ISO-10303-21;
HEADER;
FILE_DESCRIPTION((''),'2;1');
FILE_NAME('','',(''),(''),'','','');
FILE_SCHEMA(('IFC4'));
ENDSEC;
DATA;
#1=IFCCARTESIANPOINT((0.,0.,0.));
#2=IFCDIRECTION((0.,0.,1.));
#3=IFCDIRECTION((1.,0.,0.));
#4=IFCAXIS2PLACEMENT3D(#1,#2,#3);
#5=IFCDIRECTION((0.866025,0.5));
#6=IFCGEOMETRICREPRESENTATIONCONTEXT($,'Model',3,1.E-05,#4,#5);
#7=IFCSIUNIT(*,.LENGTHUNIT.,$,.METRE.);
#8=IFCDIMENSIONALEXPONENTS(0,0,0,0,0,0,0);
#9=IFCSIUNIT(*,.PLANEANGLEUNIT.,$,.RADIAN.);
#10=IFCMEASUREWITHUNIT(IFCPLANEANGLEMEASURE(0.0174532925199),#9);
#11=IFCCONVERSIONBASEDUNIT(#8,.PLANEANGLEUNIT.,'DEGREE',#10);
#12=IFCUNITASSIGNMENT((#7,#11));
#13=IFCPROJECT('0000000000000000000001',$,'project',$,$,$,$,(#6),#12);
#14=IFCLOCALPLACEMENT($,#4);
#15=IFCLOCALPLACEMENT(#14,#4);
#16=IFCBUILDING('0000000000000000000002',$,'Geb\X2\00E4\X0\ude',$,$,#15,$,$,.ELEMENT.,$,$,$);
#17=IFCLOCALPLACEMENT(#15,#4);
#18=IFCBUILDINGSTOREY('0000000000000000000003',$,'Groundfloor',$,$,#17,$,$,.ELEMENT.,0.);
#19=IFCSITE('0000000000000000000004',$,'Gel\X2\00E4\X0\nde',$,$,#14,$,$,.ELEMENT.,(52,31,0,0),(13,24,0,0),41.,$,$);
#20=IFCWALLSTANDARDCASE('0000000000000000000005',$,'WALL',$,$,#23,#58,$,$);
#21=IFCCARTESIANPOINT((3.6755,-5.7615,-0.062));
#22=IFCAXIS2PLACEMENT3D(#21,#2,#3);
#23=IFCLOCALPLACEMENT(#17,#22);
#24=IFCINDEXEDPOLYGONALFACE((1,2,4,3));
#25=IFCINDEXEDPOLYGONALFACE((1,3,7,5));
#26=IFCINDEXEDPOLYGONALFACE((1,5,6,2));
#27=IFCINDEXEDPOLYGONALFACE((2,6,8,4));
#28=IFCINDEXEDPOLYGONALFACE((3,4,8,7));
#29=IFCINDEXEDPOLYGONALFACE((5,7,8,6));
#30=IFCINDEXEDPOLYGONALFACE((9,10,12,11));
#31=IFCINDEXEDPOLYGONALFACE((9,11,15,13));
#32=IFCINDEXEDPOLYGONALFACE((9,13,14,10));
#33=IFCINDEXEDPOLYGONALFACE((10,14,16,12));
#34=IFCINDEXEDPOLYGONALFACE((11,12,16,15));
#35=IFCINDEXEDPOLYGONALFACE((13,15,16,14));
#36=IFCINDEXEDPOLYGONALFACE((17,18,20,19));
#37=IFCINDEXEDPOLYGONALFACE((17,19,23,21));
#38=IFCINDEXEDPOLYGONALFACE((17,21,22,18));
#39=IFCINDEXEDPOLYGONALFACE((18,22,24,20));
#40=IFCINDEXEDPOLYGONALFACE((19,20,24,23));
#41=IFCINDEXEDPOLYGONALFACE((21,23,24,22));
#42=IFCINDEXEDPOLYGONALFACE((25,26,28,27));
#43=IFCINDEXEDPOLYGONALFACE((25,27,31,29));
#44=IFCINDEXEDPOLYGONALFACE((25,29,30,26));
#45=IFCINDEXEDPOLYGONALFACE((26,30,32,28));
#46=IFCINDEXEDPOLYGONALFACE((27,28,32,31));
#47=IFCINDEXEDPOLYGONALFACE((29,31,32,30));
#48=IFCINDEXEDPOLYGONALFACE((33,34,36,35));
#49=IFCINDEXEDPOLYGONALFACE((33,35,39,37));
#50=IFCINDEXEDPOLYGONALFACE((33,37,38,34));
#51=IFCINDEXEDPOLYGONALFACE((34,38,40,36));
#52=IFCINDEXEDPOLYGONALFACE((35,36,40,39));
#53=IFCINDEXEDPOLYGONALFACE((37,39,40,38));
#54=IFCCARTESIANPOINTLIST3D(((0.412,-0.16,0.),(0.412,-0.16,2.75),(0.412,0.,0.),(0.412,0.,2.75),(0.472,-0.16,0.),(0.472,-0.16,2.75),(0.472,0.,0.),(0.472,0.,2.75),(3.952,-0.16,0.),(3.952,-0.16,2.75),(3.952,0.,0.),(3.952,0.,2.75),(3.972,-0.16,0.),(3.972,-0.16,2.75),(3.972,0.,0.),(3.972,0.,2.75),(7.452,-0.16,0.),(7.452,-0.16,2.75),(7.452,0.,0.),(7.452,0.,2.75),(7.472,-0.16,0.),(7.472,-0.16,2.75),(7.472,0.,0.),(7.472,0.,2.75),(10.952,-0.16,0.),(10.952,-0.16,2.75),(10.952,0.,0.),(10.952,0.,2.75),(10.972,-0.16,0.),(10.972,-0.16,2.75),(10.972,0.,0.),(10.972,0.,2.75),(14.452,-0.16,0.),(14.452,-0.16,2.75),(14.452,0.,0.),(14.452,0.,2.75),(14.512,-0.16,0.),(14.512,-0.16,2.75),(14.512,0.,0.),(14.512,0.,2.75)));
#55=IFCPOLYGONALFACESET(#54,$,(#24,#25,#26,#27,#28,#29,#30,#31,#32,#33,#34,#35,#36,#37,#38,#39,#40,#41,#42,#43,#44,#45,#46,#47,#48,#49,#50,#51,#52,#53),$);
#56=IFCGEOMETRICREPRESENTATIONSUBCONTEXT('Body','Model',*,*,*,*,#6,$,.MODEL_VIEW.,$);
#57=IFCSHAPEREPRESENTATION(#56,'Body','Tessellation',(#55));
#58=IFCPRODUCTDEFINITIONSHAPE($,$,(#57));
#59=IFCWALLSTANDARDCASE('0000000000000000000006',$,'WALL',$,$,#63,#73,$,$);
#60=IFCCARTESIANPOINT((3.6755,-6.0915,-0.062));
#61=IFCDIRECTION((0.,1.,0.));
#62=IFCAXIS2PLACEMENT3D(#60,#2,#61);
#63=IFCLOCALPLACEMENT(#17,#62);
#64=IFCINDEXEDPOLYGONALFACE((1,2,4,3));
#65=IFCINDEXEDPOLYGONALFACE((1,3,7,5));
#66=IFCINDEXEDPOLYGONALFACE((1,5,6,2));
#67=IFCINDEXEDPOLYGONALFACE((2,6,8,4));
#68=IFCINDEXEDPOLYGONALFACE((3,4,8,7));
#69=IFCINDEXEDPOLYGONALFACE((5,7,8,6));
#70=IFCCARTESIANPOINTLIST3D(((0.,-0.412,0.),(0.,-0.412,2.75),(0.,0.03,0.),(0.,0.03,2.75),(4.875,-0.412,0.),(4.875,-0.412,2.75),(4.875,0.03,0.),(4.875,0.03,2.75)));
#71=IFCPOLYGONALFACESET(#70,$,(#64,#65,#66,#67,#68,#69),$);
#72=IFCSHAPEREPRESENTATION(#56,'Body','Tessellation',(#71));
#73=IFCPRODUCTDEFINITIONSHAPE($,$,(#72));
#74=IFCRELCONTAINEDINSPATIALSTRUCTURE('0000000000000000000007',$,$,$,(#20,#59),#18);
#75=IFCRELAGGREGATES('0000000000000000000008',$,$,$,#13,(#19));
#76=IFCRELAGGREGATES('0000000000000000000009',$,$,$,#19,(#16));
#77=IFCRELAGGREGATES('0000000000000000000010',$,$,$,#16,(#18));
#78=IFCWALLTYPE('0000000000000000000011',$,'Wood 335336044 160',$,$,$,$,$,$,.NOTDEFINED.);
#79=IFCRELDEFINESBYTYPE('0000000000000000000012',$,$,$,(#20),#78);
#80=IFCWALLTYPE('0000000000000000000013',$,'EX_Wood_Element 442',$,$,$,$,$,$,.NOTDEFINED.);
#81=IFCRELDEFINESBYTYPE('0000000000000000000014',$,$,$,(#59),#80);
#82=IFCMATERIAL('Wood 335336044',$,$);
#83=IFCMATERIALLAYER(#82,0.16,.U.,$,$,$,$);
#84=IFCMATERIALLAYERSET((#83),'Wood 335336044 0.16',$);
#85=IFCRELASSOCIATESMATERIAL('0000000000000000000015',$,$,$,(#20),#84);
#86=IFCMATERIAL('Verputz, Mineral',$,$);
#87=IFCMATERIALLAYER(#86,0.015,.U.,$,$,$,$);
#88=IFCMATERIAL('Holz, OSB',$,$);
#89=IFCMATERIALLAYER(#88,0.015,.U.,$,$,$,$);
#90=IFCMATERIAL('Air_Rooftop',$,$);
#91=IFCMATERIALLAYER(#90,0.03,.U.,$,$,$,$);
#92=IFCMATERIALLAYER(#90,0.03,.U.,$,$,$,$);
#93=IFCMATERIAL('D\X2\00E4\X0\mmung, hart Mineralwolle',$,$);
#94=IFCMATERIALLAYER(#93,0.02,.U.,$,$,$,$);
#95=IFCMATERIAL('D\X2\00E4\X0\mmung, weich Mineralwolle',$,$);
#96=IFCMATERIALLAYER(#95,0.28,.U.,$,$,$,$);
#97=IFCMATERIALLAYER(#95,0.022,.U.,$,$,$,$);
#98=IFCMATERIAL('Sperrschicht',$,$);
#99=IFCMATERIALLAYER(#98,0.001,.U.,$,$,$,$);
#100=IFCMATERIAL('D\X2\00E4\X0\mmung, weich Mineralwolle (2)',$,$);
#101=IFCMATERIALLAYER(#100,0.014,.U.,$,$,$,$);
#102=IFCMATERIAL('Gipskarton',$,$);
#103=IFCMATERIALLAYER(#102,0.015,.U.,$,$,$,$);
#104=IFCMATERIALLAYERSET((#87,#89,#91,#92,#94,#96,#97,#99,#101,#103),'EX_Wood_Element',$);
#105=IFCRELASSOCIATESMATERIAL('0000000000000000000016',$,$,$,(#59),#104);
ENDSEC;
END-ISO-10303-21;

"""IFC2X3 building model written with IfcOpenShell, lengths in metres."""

from ifc_helpers import new_model, entity, si_unit, converted_unit, direction, frame, origin_with_axes, origin_2d_with_axis, place, context, subcontext, project, spatial, polyline, rectangle, outline, extrude, material, layer, layer_set, layer_usage, type_object, element, save


model = new_model("IFC2X3")

# Units and contexts
model_context = context("Model", 3, precision=1e-05, world=origin_with_axes(), true_north=direction((0.866025, 0.5)))
body_context = subcontext(model_context, "Body", "Model", "MODEL_VIEW")
ifc_project = project(units=[si_unit("LENGTHUNIT", "METRE"), converted_unit("PLANEANGLEUNIT", "DEGREE", entity("IfcPlaneAngleMeasure", 0.0174532925199), si_unit("PLANEANGLEUNIT", "RADIAN"), dimensions=[0, 0, 0, 0, 0, 0, 0])], contexts=[model_context])

# Site, building, storey
site_placement = place(None, origin_with_axes())
site = spatial("IfcSite", under=ifc_project, at=site_placement, Name="Gelände", CompositionType="ELEMENT", RefLatitude=(52, 31, 0, 0), RefLongitude=(13, 24, 0, 0), RefElevation=41.0)
building_placement = place(site_placement, origin_with_axes())
building = spatial("IfcBuilding", under=site, at=building_placement, Name="Gebäude", CompositionType="ELEMENT")
storey_placement = place(building_placement, origin_with_axes())
storey = spatial("IfcBuildingStorey", under=building, at=storey_placement, Name="Groundfloor", CompositionType="ELEMENT", Elevation=0.0)

# Shared definitions
ifc_material_1 = material(Name="Holz, OSB")
ifc_material_2 = material(Name="Dämmung, weich Mineralwolle")

# Wall, openings
ifc_material_3 = material(Name="Wood 335336044")
ifc_layer_1 = layer(ifc_material_3, 0.16, ventilated="UNKNOWN")
ifc_layer_set_1 = layer_set([ifc_layer_1], Name="Wood 335336044 0.16")
ifc_layer_usage_1 = layer_usage(ifc_layer_set_1, "AXIS2", "NEGATIVE", 0.0)
wall_type_1 = type_object("IfcWallType", Name="Wood 335336044 160", PredefinedType="NOTDEFINED")
wall_1_placement = place(storey_placement, frame((3.6755, -5.7615, -0.062), z_axis=(0.0, 0.0, 1.0), x_axis=(1.0, 0.0, 0.0)))
wall_1 = element("IfcWallStandardCase", 1, at=wall_1_placement, inside=storey, type_object=wall_type_1, material=ifc_layer_usage_1, Name="WALL", context=body_context, shape_type="SweptSolid", body=[
    extrude(outline(polyline([(0.412, -0.16), (14.512, -0.16), (14.512, 0.0), (0.412, 0.0), (0.412, -0.16)])), origin_with_axes(), (0.0, 0.0, 1.0), 2.75),
])
opening_1_placement = place(wall_1_placement, frame((5.712, 0.0, 0.0), z_axis=(0.0, 0.0, 1.0), x_axis=(1.0, 0.0, 0.0)))
element("IfcOpeningElement", 2, at=opening_1_placement, cuts=wall_1, context=body_context, shape_type="SweptSolid", body=[
    extrude(rectangle(XDim=3.48, YDim=2.75, at=origin_2d_with_axis()), frame((0.0, 0.16, 1.375), z_axis=(0.0, 1.0, 0.0), x_axis=(-1.0, 0.0, 0.0)), (0.0, 0.0, -1.0), 0.48),
])
opening_2_placement = place(wall_1_placement, frame((9.212, 0.0, 0.0), z_axis=(0.0, 0.0, 1.0), x_axis=(1.0, 0.0, 0.0)))
element("IfcOpeningElement", 3, at=opening_2_placement, cuts=wall_1, context=body_context, shape_type="SweptSolid", body=[
    extrude(rectangle(XDim=3.48, YDim=2.75, at=origin_2d_with_axis()), frame((0.0, 0.16, 1.375), z_axis=(0.0, 1.0, 0.0), x_axis=(-1.0, 0.0, 0.0)), (0.0, 0.0, -1.0), 0.48),
])
opening_3_placement = place(wall_1_placement, frame((12.712, 0.0, 0.0), z_axis=(0.0, 0.0, 1.0), x_axis=(1.0, 0.0, 0.0)))
element("IfcOpeningElement", 4, at=opening_3_placement, cuts=wall_1, context=body_context, shape_type="SweptSolid", body=[
    extrude(rectangle(XDim=3.48, YDim=2.75, at=origin_2d_with_axis()), frame((0.0, 0.16, 1.375), z_axis=(0.0, 1.0, 0.0), x_axis=(-1.0, 0.0, 0.0)), (0.0, 0.0, -1.0), 0.48),
])
opening_4_placement = place(wall_1_placement, frame((2.212, 0.0, 0.0), z_axis=(0.0, 0.0, 1.0), x_axis=(1.0, 0.0, 0.0)))
element("IfcOpeningElement", 5, at=opening_4_placement, cuts=wall_1, context=body_context, shape_type="SweptSolid", body=[
    extrude(rectangle(XDim=3.48, YDim=2.75, at=origin_2d_with_axis()), frame((0.0, 0.16, 1.375), z_axis=(0.0, 1.0, 0.0), x_axis=(-1.0, 0.0, 0.0)), (0.0, 0.0, -1.0), 0.48),
])

# Wall
ifc_material_4 = material(Name="Verputz, Mineral")
ifc_layer_2 = layer(ifc_material_4, 0.015, ventilated="UNKNOWN")
ifc_layer_3 = layer(ifc_material_1, 0.015, ventilated="UNKNOWN")
ifc_material_5 = material(Name="Air_Rooftop")
ifc_layer_4 = layer(ifc_material_5, 0.03, ventilated="UNKNOWN")
ifc_layer_5 = layer(ifc_material_5, 0.03, ventilated="UNKNOWN")
ifc_material_6 = material(Name="Dämmung, hart Mineralwolle")
ifc_layer_6 = layer(ifc_material_6, 0.02, ventilated="UNKNOWN")
ifc_layer_7 = layer(ifc_material_2, 0.28, ventilated="UNKNOWN")
ifc_layer_8 = layer(ifc_material_2, 0.022, ventilated="UNKNOWN")
ifc_material_7 = material(Name="Sperrschicht")
ifc_layer_9 = layer(ifc_material_7, 0.001, ventilated="UNKNOWN")
ifc_material_8 = material(Name="Dämmung, weich Mineralwolle (2)")
ifc_layer_10 = layer(ifc_material_8, 0.014, ventilated="UNKNOWN")
ifc_material_9 = material(Name="Gipskarton")
ifc_layer_11 = layer(ifc_material_9, 0.015, ventilated="UNKNOWN")
ifc_layer_set_2 = layer_set([ifc_layer_2, ifc_layer_3, ifc_layer_4, ifc_layer_5, ifc_layer_6, ifc_layer_7, ifc_layer_8, ifc_layer_9, ifc_layer_10, ifc_layer_11], Name="EX_Wood_Element")
ifc_layer_usage_2 = layer_usage(ifc_layer_set_2, "AXIS2", "NEGATIVE", 0.03)
wall_type_2 = type_object("IfcWallType", Name="EX_Wood_Element 442", PredefinedType="NOTDEFINED")
wall_2_placement = place(storey_placement, frame((3.6755, -6.0915, -0.062), z_axis=(0.0, 0.0, 1.0), x_axis=(0.0, 1.0, 0.0)))
element("IfcWallStandardCase", 6, at=wall_2_placement, inside=storey, type_object=wall_type_2, material=ifc_layer_usage_2, Name="WALL", context=body_context, shape_type="SweptSolid", body=[
    extrude(outline(polyline([(0.0, -0.412), (4.875, -0.412), (4.875, 0.03), (0.0, 0.03), (0.0, -0.412)])), origin_with_axes(), (0.0, 0.0, 1.0), 2.75),
])

save(model, "model.ifc")
